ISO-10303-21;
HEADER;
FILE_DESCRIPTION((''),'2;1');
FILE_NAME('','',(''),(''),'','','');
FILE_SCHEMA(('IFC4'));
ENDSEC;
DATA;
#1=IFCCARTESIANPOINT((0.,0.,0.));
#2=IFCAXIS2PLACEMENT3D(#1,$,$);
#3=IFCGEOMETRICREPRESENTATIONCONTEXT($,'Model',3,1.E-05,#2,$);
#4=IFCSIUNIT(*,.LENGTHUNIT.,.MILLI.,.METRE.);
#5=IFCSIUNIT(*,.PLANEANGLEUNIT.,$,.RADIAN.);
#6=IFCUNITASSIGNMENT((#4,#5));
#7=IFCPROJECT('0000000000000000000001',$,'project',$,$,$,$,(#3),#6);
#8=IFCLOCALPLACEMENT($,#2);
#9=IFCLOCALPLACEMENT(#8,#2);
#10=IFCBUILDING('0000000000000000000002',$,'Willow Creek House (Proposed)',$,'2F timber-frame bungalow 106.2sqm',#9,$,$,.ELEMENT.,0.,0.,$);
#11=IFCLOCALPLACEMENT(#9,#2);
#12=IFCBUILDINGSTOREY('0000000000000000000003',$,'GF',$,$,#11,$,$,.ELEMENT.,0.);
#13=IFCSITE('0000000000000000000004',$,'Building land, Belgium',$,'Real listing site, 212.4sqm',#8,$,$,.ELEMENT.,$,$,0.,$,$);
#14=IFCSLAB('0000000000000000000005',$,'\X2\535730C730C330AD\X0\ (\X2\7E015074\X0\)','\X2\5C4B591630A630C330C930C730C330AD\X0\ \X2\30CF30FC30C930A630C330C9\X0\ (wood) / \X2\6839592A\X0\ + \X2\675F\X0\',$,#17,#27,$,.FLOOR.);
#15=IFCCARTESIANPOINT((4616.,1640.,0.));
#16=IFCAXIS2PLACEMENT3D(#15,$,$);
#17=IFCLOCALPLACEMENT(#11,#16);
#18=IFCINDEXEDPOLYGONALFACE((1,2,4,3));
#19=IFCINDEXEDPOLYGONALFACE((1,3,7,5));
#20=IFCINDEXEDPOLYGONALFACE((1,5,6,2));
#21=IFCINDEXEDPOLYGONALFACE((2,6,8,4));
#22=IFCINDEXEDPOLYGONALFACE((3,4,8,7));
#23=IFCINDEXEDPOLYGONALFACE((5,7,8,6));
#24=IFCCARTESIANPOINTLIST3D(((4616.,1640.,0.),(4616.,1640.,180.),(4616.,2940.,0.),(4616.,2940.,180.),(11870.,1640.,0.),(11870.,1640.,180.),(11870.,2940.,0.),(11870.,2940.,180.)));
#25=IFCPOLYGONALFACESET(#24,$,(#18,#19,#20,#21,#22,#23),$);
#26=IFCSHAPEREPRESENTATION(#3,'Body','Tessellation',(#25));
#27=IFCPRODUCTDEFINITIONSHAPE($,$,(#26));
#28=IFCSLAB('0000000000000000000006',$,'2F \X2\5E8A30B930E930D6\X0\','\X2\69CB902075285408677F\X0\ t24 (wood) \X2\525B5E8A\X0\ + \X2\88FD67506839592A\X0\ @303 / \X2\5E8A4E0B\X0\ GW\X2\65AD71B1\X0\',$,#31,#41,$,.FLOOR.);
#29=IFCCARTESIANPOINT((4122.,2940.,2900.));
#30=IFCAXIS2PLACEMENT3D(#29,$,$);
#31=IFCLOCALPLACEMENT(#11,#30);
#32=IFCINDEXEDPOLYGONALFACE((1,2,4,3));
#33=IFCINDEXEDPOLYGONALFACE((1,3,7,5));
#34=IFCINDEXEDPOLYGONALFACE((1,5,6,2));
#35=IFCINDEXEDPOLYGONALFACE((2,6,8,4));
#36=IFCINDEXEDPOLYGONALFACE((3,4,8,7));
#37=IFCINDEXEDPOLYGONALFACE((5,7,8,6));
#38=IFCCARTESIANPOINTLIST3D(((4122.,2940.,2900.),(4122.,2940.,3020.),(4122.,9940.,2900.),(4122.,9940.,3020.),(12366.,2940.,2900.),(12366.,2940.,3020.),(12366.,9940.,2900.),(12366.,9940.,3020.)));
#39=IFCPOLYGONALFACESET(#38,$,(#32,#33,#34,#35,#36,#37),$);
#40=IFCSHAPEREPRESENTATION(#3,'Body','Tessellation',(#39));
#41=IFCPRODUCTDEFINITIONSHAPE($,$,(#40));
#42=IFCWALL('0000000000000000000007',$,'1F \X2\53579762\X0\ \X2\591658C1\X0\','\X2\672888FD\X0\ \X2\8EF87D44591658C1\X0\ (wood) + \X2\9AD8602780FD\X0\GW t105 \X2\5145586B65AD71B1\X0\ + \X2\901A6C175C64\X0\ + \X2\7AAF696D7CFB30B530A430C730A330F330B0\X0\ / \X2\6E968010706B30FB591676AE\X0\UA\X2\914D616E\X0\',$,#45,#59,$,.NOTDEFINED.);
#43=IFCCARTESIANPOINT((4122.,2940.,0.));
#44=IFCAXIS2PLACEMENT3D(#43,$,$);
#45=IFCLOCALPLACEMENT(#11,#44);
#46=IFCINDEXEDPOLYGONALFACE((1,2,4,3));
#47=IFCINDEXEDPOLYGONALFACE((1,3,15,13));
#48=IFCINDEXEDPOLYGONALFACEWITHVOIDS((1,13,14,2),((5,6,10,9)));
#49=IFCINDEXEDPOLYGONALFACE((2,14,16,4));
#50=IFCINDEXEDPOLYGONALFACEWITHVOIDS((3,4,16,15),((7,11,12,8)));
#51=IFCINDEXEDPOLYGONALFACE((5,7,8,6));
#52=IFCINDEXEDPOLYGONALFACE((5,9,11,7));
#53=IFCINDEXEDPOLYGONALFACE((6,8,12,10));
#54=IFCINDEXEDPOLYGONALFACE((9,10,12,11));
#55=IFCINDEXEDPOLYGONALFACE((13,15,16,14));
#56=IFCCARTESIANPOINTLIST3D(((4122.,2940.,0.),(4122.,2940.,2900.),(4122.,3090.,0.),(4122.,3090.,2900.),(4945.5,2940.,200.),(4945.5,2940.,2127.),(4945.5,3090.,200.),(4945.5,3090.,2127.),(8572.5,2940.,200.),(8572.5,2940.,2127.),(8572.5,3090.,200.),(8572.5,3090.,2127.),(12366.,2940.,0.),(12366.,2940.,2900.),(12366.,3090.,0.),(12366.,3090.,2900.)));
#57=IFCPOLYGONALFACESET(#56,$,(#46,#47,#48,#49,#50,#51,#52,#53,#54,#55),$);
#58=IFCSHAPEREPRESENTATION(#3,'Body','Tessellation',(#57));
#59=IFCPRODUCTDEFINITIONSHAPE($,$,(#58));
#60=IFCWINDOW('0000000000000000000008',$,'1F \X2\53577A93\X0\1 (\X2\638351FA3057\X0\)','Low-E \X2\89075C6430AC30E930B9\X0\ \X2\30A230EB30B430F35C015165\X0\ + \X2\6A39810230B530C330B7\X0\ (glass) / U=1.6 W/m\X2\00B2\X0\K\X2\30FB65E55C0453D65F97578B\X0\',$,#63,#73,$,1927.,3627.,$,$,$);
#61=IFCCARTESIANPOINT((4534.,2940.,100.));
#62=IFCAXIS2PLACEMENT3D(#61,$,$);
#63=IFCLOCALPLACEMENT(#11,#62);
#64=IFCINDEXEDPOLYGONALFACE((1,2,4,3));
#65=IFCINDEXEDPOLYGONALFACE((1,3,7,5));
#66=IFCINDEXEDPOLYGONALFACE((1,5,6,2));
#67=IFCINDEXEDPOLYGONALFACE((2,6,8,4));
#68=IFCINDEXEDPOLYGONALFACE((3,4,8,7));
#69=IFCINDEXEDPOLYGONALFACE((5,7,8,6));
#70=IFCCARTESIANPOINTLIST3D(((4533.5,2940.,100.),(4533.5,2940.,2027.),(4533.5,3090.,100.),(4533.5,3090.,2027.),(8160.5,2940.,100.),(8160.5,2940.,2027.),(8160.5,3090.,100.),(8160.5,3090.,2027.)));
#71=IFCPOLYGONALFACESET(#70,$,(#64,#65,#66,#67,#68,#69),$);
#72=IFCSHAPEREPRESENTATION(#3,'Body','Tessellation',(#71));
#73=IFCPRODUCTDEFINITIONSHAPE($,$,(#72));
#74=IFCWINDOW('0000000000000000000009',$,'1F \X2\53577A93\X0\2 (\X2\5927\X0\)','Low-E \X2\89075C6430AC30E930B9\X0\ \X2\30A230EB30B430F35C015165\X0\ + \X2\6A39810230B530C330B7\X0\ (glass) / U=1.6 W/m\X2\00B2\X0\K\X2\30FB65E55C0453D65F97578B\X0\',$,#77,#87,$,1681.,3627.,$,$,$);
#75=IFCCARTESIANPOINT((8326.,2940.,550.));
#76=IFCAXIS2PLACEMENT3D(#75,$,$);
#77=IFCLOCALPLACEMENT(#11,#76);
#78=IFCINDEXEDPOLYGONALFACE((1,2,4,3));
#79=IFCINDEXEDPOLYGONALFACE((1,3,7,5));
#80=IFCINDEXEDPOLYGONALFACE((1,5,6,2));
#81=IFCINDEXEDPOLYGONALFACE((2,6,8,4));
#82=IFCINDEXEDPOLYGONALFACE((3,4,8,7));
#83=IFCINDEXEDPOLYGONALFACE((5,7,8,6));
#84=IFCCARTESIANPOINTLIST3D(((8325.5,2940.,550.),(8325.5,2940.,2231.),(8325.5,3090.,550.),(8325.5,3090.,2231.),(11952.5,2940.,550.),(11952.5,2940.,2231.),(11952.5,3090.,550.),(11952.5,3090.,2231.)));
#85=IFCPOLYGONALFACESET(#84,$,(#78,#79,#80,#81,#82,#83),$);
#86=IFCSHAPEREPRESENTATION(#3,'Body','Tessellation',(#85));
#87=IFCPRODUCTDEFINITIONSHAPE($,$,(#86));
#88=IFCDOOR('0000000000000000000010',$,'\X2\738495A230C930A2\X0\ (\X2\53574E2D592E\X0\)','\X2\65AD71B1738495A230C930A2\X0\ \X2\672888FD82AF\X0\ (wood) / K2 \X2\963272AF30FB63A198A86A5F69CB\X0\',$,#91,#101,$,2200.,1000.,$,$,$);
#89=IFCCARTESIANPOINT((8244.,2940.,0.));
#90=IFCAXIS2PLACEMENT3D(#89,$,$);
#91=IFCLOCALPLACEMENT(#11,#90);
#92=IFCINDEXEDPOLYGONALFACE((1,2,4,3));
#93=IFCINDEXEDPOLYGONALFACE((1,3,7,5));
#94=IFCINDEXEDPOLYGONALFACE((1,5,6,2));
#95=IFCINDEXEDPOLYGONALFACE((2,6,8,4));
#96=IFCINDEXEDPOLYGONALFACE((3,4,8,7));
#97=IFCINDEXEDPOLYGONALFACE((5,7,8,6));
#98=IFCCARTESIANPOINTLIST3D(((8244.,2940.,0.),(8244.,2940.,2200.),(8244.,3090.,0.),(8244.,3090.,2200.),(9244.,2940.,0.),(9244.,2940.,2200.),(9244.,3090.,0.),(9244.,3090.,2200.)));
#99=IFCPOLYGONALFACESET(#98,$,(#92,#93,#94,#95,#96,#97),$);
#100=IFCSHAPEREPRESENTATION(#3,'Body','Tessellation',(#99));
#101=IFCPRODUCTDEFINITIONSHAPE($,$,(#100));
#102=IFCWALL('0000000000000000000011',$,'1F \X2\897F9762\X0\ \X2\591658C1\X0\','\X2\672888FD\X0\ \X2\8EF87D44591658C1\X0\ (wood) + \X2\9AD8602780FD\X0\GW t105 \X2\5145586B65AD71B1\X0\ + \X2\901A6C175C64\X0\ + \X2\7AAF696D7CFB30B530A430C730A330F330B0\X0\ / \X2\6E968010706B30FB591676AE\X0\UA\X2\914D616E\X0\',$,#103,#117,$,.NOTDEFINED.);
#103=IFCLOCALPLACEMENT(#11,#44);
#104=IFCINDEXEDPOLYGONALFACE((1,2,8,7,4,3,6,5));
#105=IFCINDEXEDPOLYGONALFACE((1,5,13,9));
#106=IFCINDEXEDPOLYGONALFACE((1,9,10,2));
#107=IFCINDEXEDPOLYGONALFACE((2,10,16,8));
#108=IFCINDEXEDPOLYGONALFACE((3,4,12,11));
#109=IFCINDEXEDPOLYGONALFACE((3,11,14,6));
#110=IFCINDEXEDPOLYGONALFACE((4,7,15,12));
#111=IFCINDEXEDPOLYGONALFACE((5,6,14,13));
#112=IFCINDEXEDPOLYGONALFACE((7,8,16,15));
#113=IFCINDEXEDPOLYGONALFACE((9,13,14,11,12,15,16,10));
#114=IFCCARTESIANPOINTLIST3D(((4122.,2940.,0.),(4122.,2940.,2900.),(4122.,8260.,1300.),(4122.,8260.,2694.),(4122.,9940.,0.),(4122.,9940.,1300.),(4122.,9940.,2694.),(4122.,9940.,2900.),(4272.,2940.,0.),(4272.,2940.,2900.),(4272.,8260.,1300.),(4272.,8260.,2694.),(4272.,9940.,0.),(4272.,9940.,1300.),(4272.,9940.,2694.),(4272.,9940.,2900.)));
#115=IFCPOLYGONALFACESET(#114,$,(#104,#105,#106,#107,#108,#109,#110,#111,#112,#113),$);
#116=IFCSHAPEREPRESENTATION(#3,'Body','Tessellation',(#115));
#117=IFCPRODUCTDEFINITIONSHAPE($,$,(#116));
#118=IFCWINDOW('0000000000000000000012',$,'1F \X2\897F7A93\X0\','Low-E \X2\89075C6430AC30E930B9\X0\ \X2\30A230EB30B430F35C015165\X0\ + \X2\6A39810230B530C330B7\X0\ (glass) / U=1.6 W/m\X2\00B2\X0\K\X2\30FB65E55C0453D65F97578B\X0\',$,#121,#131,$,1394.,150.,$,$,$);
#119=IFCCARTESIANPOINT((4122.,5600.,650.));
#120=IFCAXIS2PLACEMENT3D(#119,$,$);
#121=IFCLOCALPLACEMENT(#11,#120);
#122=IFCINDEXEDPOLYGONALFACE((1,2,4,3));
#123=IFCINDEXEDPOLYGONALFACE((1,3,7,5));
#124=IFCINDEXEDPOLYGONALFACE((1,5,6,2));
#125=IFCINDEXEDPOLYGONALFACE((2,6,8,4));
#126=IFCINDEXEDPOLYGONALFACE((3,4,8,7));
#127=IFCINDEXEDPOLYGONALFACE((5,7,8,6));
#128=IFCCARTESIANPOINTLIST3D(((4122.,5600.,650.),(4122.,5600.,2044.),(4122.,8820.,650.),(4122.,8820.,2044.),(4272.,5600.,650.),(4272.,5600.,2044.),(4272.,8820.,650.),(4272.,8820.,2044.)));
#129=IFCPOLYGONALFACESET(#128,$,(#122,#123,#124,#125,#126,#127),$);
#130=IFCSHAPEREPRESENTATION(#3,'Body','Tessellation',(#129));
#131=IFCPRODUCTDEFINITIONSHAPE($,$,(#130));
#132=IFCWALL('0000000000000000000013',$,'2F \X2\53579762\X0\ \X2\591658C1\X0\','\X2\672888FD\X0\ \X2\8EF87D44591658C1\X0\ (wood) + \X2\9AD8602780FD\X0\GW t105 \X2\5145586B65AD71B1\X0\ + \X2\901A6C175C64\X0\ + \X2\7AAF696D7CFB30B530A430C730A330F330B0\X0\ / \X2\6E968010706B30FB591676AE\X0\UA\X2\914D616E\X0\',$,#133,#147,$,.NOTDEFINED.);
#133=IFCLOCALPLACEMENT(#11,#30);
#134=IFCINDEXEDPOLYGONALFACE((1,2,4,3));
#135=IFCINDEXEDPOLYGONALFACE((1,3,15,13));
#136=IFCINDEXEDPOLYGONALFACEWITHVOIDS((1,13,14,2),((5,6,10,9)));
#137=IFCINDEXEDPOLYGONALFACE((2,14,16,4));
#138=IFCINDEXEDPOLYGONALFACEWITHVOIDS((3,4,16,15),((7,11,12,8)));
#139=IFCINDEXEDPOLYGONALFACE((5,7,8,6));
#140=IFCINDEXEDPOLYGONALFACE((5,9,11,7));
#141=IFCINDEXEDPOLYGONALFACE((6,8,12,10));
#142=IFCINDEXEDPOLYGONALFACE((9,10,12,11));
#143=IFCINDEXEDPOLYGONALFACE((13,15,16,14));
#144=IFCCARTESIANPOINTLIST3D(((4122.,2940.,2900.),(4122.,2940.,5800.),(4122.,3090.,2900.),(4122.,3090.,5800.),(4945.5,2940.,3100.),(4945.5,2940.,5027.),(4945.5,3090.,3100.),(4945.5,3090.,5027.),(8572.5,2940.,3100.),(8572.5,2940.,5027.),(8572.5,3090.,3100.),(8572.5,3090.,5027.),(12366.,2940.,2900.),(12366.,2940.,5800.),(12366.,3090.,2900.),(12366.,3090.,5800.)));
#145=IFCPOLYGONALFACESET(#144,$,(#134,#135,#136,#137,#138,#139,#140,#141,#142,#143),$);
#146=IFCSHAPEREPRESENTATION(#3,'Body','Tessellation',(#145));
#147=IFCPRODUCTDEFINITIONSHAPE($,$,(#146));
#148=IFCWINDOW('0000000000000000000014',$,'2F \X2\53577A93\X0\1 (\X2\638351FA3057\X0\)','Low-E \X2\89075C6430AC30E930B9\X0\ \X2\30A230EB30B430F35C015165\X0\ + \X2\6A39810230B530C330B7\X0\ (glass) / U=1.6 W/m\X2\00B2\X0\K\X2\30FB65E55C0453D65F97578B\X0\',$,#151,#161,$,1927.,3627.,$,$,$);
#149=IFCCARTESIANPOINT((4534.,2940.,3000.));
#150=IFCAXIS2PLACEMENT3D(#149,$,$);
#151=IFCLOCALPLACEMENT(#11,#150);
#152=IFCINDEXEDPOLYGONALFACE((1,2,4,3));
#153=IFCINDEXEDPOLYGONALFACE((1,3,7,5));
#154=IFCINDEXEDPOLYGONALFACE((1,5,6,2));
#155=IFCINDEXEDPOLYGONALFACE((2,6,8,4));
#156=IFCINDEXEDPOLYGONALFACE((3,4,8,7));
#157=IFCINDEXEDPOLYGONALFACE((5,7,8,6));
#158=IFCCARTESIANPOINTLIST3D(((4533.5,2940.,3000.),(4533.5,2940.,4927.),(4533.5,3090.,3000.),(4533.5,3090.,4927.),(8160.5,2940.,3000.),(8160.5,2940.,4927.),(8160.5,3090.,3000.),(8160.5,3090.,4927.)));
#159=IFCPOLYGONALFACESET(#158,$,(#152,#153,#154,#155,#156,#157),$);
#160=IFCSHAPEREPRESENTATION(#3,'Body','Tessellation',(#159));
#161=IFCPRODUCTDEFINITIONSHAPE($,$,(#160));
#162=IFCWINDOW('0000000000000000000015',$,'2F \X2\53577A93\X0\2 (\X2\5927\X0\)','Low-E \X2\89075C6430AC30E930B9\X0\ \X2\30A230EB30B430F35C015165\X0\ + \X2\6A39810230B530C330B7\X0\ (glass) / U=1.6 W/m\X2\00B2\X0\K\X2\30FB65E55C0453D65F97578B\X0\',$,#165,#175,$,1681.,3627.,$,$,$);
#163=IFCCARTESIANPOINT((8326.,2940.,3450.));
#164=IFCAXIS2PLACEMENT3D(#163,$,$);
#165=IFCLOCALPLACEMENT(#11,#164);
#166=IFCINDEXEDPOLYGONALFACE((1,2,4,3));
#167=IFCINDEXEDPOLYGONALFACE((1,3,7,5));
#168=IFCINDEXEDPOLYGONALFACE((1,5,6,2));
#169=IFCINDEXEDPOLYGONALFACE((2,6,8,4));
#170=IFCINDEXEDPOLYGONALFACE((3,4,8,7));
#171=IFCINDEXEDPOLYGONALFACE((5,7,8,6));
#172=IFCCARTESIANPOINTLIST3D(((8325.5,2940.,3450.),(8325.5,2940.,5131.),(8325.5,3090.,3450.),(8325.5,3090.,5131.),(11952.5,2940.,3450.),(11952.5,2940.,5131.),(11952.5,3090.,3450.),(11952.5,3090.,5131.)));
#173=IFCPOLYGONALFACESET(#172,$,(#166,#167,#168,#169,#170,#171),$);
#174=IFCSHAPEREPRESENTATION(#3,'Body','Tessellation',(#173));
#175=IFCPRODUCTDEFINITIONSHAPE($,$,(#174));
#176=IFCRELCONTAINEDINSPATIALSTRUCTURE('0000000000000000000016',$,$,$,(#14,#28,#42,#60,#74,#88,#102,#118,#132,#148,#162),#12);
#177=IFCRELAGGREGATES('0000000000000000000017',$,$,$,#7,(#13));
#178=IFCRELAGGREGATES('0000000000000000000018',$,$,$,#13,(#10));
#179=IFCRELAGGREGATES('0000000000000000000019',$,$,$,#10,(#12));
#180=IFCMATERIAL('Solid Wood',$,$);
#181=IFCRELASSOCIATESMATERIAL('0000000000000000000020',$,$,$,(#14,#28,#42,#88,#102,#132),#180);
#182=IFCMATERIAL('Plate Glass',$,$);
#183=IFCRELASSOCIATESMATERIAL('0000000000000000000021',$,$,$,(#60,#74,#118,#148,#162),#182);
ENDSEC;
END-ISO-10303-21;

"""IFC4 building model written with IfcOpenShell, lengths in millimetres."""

from ifc_helpers import new_model, si_unit, frame, frame_2d, origin, place, context, project, spatial, rectangle, extrude, material, element, fill, save


model = new_model("IFC4")

# Units and contexts
model_context = context("Model", 3, precision=1e-05, world=origin())
ifc_project = project(units=[si_unit("LENGTHUNIT", "METRE", prefix="MILLI"), si_unit("PLANEANGLEUNIT", "RADIAN")], contexts=[model_context])

# Site, building, storey
site_placement = place(None, origin())
site = spatial("IfcSite", under=ifc_project, at=site_placement, Name="Building land, Belgium", ObjectType="Real listing site, 212.4sqm", CompositionType="ELEMENT", RefElevation=0.0)
building_placement = place(site_placement, origin())
building = spatial("IfcBuilding", under=site, at=building_placement, Name="Willow Creek House (Proposed)", ObjectType="2F timber-frame bungalow 106.2sqm", CompositionType="ELEMENT", ElevationOfRefHeight=0.0, ElevationOfTerrain=0.0)
storey_placement = place(building_placement, origin())
storey = spatial("IfcBuildingStorey", under=building, at=storey_placement, Name="GF", CompositionType="ELEMENT", Elevation=0.0)

# Slabs
ifc_material_1 = material(Name="Solid Wood")
slab_1_placement = place(storey_placement, frame((4616.0, 1640.0, 0.0)))
element("IfcSlab", 1, at=slab_1_placement, inside=storey, material=ifc_material_1, Name="南デッキ (縁側)", Description="屋外ウッドデッキ ハードウッド (wood) / 根太 + 束", PredefinedType="FLOOR", context=model_context, shape_type="SweptSolid", body=[
    extrude(rectangle(XDim=7254.0, YDim=1300.0, at=frame_2d((3627.0, 650.0))), frame((4616.0, 1640.0, 0.0)), (0.0, 0.0, 1.0), 180.0),
])
slab_2_placement = place(storey_placement, frame((4122.0, 2940.0, 2900.0)))
element("IfcSlab", 2, at=slab_2_placement, inside=storey, material=ifc_material_1, Name="2F 床スラブ", Description="構造用合板 t24 (wood) 剛床 + 製材根太 @303 / 床下 GW断熱", PredefinedType="FLOOR", context=model_context, shape_type="SweptSolid", body=[
    extrude(rectangle(XDim=8244.0, YDim=7000.0, at=frame_2d((4122.0, 3500.0))), frame((4122.0, 2940.0, 2900.0)), (0.0, 0.0, 1.0), 120.0),
])

# Wall, openings, windows, door
wall_1_placement = place(storey_placement, frame((4122.0, 2940.0, 0.0)))
wall_1 = element("IfcWall", 3, at=wall_1_placement, inside=storey, material=ifc_material_1, Name="1F 南面 外壁", Description="木製 軸組外壁 (wood) + 高性能GW t105 充填断熱 + 通気層 + 窯業系サイディング / 準耐火・外皮UA配慮", PredefinedType="NOTDEFINED", context=model_context, shape_type="SweptSolid", body=[
    extrude(rectangle(XDim=8244.0, YDim=150.0, at=frame_2d((4122.0, 75.0))), frame((4122.0, 2940.0, 0.0)), (0.0, 0.0, 1.0), 2900.0),
])
opening_1_placement = place(storey_placement, frame((4534.0, 2940.0, 100.0)))
opening_1 = element("IfcOpeningElement", 4, at=opening_1_placement, cuts=wall_1, PredefinedType="NOTDEFINED", context=model_context, shape_type="SweptSolid", body=[
    extrude(rectangle(XDim=3627.0, YDim=150.0, at=frame_2d((1813.0, 75.0))), frame((4534.0, 2940.0, 100.0)), (0.0, 0.0, 1.0), 1927.0),
])
opening_2_placement = place(storey_placement, frame((8326.0, 2940.0, 550.0)))
opening_2 = element("IfcOpeningElement", 5, at=opening_2_placement, cuts=wall_1, PredefinedType="NOTDEFINED", context=model_context, shape_type="SweptSolid", body=[
    extrude(rectangle(XDim=3627.0, YDim=150.0, at=frame_2d((1813.0, 75.0))), frame((8326.0, 2940.0, 550.0)), (0.0, 0.0, 1.0), 1681.0),
])
opening_3_placement = place(storey_placement, frame((8244.0, 2940.0, 0.0)))
opening_3 = element("IfcOpeningElement", 6, at=opening_3_placement, cuts=wall_1, PredefinedType="NOTDEFINED", context=model_context, shape_type="SweptSolid", body=[
    extrude(rectangle(XDim=1000.0, YDim=150.0, at=frame_2d((500.0, 75.0))), frame((8244.0, 2940.0, 0.0)), (0.0, 0.0, 1.0), 2200.0),
])
ifc_material_2 = material(Name="Plate Glass")
window_1_placement = place(storey_placement, frame((4534.0, 2940.0, 100.0)))
window_1 = element("IfcWindow", 7, at=window_1_placement, inside=storey, material=ifc_material_2, Name="1F 南窓1 (掃出し)", Description="Low-E 複層ガラス アルゴン封入 + 樹脂サッシ (glass) / U=1.6 W/m²K・日射取得型", OverallHeight=1927.0, OverallWidth=3627.0, context=model_context, shape_type="SweptSolid", body=[
    extrude(rectangle(XDim=3627.0, YDim=150.0, at=frame_2d((1813.0, 75.0))), frame((4534.0, 2940.0, 100.0)), (0.0, 0.0, 1.0), 1927.0),
])
fill(opening_1, window_1)
window_2_placement = place(storey_placement, frame((8326.0, 2940.0, 550.0)))
window_2 = element("IfcWindow", 8, at=window_2_placement, inside=storey, material=ifc_material_2, Name="1F 南窓2 (大)", Description="Low-E 複層ガラス アルゴン封入 + 樹脂サッシ (glass) / U=1.6 W/m²K・日射取得型", OverallHeight=1681.0, OverallWidth=3627.0, context=model_context, shape_type="SweptSolid", body=[
    extrude(rectangle(XDim=3627.0, YDim=150.0, at=frame_2d((1813.0, 75.0))), frame((8326.0, 2940.0, 550.0)), (0.0, 0.0, 1.0), 1681.0),
])
fill(opening_2, window_2)
door_placement = place(storey_placement, frame((8244.0, 2940.0, 0.0)))
door = element("IfcDoor", 9, at=door_placement, inside=storey, material=ifc_material_1, Name="玄関ドア (南中央)", Description="断熱玄関ドア 木製芯 (wood) / K2 防犯・採風機構", OverallHeight=2200.0, OverallWidth=1000.0, context=model_context, shape_type="SweptSolid", body=[
    extrude(rectangle(XDim=1000.0, YDim=150.0, at=frame_2d((500.0, 75.0))), frame((8244.0, 2940.0, 0.0)), (0.0, 0.0, 1.0), 2200.0),
])
fill(opening_3, door)

# Wall, opening, window
wall_2_placement = place(storey_placement, frame((4122.0, 2940.0, 0.0)))
wall_2 = element("IfcWall", 10, at=wall_2_placement, inside=storey, material=ifc_material_1, Name="1F 西面 外壁", Description="木製 軸組外壁 (wood) + 高性能GW t105 充填断熱 + 通気層 + 窯業系サイディング / 準耐火・外皮UA配慮", PredefinedType="NOTDEFINED", context=model_context, shape_type="SweptSolid", body=[
    extrude(rectangle(XDim=150.0, YDim=7000.0, at=frame_2d((75.0, 3500.0))), frame((4122.0, 2940.0, 0.0)), (0.0, 0.0, 1.0), 2900.0),
])
opening_4_placement = place(storey_placement, frame((4122.0, 5600.0, 650.0)))
opening_4 = element("IfcOpeningElement", 11, at=opening_4_placement, cuts=wall_2, PredefinedType="NOTDEFINED", context=model_context, shape_type="SweptSolid", body=[
    extrude(rectangle(XDim=150.0, YDim=3220.0, at=frame_2d((75.0, 1610.0))), frame((4122.0, 5600.0, 650.0)), (0.0, 0.0, 1.0), 1394.0),
])
window_3_placement = place(storey_placement, frame((4122.0, 5600.0, 650.0)))
window_3 = element("IfcWindow", 12, at=window_3_placement, inside=storey, material=ifc_material_2, Name="1F 西窓", Description="Low-E 複層ガラス アルゴン封入 + 樹脂サッシ (glass) / U=1.6 W/m²K・日射取得型", OverallHeight=1394.0, OverallWidth=150.0, context=model_context, shape_type="SweptSolid", body=[
    extrude(rectangle(XDim=150.0, YDim=3220.0, at=frame_2d((75.0, 1610.0))), frame((4122.0, 5600.0, 650.0)), (0.0, 0.0, 1.0), 1394.0),
])
fill(opening_4, window_3)

# Wall, openings, windows
wall_3_placement = place(storey_placement, frame((4122.0, 2940.0, 2900.0)))
wall_3 = element("IfcWall", 13, at=wall_3_placement, inside=storey, material=ifc_material_1, Name="2F 南面 外壁", Description="木製 軸組外壁 (wood) + 高性能GW t105 充填断熱 + 通気層 + 窯業系サイディング / 準耐火・外皮UA配慮", PredefinedType="NOTDEFINED", context=model_context, shape_type="SweptSolid", body=[
    extrude(rectangle(XDim=8244.0, YDim=150.0, at=frame_2d((4122.0, 75.0))), frame((4122.0, 2940.0, 2900.0)), (0.0, 0.0, 1.0), 2900.0),
])
opening_5_placement = place(storey_placement, frame((4534.0, 2940.0, 3000.0)))
opening_5 = element("IfcOpeningElement", 14, at=opening_5_placement, cuts=wall_3, PredefinedType="NOTDEFINED", context=model_context, shape_type="SweptSolid", body=[
    extrude(rectangle(XDim=3627.0, YDim=150.0, at=frame_2d((1813.0, 75.0))), frame((4534.0, 2940.0, 3000.0)), (0.0, 0.0, 1.0), 1927.0),
])
opening_6_placement = place(storey_placement, frame((8326.0, 2940.0, 3450.0)))
opening_6 = element("IfcOpeningElement", 15, at=opening_6_placement, cuts=wall_3, PredefinedType="NOTDEFINED", context=model_context, shape_type="SweptSolid", body=[
    extrude(rectangle(XDim=3627.0, YDim=150.0, at=frame_2d((1813.0, 75.0))), frame((8326.0, 2940.0, 3450.0)), (0.0, 0.0, 1.0), 1681.0),
])
window_4_placement = place(storey_placement, frame((4534.0, 2940.0, 3000.0)))
window_4 = element("IfcWindow", 16, at=window_4_placement, inside=storey, material=ifc_material_2, Name="2F 南窓1 (掃出し)", Description="Low-E 複層ガラス アルゴン封入 + 樹脂サッシ (glass) / U=1.6 W/m²K・日射取得型", OverallHeight=1927.0, OverallWidth=3627.0, context=model_context, shape_type="SweptSolid", body=[
    extrude(rectangle(XDim=3627.0, YDim=150.0, at=frame_2d((1813.0, 75.0))), frame((4534.0, 2940.0, 3000.0)), (0.0, 0.0, 1.0), 1927.0),
])
fill(opening_5, window_4)
window_5_placement = place(storey_placement, frame((8326.0, 2940.0, 3450.0)))
window_5 = element("IfcWindow", 17, at=window_5_placement, inside=storey, material=ifc_material_2, Name="2F 南窓2 (大)", Description="Low-E 複層ガラス アルゴン封入 + 樹脂サッシ (glass) / U=1.6 W/m²K・日射取得型", OverallHeight=1681.0, OverallWidth=3627.0, context=model_context, shape_type="SweptSolid", body=[
    extrude(rectangle(XDim=3627.0, YDim=150.0, at=frame_2d((1813.0, 75.0))), frame((8326.0, 2940.0, 3450.0)), (0.0, 0.0, 1.0), 1681.0),
])
fill(opening_6, window_5)

save(model, "model.ifc")
